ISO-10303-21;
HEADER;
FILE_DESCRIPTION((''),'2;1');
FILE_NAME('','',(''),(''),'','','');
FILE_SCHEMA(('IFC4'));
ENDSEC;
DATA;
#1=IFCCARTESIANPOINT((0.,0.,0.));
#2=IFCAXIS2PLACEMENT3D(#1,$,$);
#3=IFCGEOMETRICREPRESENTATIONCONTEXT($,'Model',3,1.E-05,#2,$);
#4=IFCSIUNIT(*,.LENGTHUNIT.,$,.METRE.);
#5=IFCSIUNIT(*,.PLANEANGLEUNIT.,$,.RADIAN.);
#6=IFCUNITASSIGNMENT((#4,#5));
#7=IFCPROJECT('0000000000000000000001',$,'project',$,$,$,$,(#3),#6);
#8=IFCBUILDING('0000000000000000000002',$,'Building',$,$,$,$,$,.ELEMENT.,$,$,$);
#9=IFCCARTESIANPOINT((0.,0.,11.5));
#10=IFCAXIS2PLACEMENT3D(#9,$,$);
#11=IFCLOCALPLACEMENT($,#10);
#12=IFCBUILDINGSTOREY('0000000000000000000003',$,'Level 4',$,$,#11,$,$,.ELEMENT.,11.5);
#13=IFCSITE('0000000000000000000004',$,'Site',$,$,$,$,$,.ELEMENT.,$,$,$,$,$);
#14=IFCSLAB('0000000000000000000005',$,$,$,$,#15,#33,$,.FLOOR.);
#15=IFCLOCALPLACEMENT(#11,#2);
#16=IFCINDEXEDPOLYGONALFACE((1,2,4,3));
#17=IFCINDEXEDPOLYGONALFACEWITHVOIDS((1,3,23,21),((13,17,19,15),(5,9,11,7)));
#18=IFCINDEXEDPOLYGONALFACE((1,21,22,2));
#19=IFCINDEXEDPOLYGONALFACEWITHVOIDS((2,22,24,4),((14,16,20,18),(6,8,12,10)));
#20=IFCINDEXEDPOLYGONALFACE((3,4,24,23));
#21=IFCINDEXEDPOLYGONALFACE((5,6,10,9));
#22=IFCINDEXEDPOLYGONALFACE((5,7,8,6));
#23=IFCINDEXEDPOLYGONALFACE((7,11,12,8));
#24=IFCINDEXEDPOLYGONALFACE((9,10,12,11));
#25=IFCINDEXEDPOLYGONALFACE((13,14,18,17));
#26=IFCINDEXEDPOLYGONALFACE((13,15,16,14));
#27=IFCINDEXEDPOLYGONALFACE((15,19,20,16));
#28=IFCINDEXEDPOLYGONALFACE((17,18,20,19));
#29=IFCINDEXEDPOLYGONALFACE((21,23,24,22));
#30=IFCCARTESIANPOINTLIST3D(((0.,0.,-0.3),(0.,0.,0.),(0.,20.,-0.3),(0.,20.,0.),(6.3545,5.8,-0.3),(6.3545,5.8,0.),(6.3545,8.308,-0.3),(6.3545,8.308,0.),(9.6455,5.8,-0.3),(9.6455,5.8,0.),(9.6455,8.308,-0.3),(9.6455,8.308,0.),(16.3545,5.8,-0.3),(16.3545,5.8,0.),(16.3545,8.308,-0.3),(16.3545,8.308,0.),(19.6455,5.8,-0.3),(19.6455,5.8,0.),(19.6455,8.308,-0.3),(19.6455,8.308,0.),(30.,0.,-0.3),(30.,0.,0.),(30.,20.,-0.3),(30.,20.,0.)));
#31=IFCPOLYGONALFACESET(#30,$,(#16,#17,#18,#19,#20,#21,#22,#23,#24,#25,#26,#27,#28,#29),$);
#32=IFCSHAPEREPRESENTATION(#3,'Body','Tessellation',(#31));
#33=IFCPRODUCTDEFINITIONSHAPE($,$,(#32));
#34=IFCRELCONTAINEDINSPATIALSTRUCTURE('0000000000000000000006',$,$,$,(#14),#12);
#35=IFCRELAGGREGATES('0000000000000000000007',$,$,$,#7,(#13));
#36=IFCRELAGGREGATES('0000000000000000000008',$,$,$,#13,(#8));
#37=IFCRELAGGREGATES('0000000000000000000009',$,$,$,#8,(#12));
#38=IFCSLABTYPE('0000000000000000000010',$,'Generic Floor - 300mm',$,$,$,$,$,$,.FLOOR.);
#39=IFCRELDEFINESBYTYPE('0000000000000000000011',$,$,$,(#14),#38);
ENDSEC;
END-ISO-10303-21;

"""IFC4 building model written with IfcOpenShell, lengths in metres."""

from ifc_helpers import new_model, si_unit, frame, origin, place, context, project, spatial, polyline, outline, extrude, type_object, element, save


model = new_model("IFC4")

# Units and contexts
model_context = context("Model", 3, precision=1e-05, world=origin())
ifc_project = project(units=[si_unit("LENGTHUNIT", "METRE"), si_unit("PLANEANGLEUNIT", "RADIAN")], contexts=[model_context])

# Site, building, storey
site = spatial("IfcSite", under=ifc_project, Name="Site", CompositionType="ELEMENT")
building = spatial("IfcBuilding", under=site, Name="Building", CompositionType="ELEMENT")
storey_placement = place(None, frame((0.0, 0.0, 11.5)))
storey = spatial("IfcBuildingStorey", under=building, at=storey_placement, Name="Level 4", CompositionType="ELEMENT", Elevation=11.5)

# Slab, openings
slab_type = type_object("IfcSlabType", Name="Generic Floor - 300mm", PredefinedType="FLOOR")
slab_placement = place(None, frame((0.0, 0.0, 11.5)))
slab = element("IfcSlab", 1, at=slab_placement, inside=storey, type_object=slab_type, PredefinedType="FLOOR", context=model_context, shape_type="SweptSolid", body=[
    extrude(outline(polyline([(0.0, 0.0), (30.0, 0.0), (30.0, 20.0), (0.0, 20.0), (0.0, 0.0)])), origin(), (0.0, 0.0, -1.0), 0.3),
])
opening_1_placement = place(None, frame((0.0, 0.0, 11.501)))
element("IfcOpeningElement", 2, at=opening_1_placement, cuts=slab, PredefinedType="OPENING", context=model_context, shape_type="SweptSolid", body=[
    extrude(outline(polyline([(6.3545, 5.8), (9.6455, 5.8), (9.6455, 8.308), (6.3545, 8.308), (6.3545, 5.8)])), origin(), (0.0, 0.0, -1.0), 0.302),
])
opening_2_placement = place(None, frame((0.0, 0.0, 11.501)))
element("IfcOpeningElement", 3, at=opening_2_placement, cuts=slab, PredefinedType="OPENING", context=model_context, shape_type="SweptSolid", body=[
    extrude(outline(polyline([(16.3545, 5.8), (19.6455, 5.8), (19.6455, 8.308), (16.3545, 8.308), (16.3545, 5.8)])), origin(), (0.0, 0.0, -1.0), 0.302),
])

save(model, "model.ifc")
